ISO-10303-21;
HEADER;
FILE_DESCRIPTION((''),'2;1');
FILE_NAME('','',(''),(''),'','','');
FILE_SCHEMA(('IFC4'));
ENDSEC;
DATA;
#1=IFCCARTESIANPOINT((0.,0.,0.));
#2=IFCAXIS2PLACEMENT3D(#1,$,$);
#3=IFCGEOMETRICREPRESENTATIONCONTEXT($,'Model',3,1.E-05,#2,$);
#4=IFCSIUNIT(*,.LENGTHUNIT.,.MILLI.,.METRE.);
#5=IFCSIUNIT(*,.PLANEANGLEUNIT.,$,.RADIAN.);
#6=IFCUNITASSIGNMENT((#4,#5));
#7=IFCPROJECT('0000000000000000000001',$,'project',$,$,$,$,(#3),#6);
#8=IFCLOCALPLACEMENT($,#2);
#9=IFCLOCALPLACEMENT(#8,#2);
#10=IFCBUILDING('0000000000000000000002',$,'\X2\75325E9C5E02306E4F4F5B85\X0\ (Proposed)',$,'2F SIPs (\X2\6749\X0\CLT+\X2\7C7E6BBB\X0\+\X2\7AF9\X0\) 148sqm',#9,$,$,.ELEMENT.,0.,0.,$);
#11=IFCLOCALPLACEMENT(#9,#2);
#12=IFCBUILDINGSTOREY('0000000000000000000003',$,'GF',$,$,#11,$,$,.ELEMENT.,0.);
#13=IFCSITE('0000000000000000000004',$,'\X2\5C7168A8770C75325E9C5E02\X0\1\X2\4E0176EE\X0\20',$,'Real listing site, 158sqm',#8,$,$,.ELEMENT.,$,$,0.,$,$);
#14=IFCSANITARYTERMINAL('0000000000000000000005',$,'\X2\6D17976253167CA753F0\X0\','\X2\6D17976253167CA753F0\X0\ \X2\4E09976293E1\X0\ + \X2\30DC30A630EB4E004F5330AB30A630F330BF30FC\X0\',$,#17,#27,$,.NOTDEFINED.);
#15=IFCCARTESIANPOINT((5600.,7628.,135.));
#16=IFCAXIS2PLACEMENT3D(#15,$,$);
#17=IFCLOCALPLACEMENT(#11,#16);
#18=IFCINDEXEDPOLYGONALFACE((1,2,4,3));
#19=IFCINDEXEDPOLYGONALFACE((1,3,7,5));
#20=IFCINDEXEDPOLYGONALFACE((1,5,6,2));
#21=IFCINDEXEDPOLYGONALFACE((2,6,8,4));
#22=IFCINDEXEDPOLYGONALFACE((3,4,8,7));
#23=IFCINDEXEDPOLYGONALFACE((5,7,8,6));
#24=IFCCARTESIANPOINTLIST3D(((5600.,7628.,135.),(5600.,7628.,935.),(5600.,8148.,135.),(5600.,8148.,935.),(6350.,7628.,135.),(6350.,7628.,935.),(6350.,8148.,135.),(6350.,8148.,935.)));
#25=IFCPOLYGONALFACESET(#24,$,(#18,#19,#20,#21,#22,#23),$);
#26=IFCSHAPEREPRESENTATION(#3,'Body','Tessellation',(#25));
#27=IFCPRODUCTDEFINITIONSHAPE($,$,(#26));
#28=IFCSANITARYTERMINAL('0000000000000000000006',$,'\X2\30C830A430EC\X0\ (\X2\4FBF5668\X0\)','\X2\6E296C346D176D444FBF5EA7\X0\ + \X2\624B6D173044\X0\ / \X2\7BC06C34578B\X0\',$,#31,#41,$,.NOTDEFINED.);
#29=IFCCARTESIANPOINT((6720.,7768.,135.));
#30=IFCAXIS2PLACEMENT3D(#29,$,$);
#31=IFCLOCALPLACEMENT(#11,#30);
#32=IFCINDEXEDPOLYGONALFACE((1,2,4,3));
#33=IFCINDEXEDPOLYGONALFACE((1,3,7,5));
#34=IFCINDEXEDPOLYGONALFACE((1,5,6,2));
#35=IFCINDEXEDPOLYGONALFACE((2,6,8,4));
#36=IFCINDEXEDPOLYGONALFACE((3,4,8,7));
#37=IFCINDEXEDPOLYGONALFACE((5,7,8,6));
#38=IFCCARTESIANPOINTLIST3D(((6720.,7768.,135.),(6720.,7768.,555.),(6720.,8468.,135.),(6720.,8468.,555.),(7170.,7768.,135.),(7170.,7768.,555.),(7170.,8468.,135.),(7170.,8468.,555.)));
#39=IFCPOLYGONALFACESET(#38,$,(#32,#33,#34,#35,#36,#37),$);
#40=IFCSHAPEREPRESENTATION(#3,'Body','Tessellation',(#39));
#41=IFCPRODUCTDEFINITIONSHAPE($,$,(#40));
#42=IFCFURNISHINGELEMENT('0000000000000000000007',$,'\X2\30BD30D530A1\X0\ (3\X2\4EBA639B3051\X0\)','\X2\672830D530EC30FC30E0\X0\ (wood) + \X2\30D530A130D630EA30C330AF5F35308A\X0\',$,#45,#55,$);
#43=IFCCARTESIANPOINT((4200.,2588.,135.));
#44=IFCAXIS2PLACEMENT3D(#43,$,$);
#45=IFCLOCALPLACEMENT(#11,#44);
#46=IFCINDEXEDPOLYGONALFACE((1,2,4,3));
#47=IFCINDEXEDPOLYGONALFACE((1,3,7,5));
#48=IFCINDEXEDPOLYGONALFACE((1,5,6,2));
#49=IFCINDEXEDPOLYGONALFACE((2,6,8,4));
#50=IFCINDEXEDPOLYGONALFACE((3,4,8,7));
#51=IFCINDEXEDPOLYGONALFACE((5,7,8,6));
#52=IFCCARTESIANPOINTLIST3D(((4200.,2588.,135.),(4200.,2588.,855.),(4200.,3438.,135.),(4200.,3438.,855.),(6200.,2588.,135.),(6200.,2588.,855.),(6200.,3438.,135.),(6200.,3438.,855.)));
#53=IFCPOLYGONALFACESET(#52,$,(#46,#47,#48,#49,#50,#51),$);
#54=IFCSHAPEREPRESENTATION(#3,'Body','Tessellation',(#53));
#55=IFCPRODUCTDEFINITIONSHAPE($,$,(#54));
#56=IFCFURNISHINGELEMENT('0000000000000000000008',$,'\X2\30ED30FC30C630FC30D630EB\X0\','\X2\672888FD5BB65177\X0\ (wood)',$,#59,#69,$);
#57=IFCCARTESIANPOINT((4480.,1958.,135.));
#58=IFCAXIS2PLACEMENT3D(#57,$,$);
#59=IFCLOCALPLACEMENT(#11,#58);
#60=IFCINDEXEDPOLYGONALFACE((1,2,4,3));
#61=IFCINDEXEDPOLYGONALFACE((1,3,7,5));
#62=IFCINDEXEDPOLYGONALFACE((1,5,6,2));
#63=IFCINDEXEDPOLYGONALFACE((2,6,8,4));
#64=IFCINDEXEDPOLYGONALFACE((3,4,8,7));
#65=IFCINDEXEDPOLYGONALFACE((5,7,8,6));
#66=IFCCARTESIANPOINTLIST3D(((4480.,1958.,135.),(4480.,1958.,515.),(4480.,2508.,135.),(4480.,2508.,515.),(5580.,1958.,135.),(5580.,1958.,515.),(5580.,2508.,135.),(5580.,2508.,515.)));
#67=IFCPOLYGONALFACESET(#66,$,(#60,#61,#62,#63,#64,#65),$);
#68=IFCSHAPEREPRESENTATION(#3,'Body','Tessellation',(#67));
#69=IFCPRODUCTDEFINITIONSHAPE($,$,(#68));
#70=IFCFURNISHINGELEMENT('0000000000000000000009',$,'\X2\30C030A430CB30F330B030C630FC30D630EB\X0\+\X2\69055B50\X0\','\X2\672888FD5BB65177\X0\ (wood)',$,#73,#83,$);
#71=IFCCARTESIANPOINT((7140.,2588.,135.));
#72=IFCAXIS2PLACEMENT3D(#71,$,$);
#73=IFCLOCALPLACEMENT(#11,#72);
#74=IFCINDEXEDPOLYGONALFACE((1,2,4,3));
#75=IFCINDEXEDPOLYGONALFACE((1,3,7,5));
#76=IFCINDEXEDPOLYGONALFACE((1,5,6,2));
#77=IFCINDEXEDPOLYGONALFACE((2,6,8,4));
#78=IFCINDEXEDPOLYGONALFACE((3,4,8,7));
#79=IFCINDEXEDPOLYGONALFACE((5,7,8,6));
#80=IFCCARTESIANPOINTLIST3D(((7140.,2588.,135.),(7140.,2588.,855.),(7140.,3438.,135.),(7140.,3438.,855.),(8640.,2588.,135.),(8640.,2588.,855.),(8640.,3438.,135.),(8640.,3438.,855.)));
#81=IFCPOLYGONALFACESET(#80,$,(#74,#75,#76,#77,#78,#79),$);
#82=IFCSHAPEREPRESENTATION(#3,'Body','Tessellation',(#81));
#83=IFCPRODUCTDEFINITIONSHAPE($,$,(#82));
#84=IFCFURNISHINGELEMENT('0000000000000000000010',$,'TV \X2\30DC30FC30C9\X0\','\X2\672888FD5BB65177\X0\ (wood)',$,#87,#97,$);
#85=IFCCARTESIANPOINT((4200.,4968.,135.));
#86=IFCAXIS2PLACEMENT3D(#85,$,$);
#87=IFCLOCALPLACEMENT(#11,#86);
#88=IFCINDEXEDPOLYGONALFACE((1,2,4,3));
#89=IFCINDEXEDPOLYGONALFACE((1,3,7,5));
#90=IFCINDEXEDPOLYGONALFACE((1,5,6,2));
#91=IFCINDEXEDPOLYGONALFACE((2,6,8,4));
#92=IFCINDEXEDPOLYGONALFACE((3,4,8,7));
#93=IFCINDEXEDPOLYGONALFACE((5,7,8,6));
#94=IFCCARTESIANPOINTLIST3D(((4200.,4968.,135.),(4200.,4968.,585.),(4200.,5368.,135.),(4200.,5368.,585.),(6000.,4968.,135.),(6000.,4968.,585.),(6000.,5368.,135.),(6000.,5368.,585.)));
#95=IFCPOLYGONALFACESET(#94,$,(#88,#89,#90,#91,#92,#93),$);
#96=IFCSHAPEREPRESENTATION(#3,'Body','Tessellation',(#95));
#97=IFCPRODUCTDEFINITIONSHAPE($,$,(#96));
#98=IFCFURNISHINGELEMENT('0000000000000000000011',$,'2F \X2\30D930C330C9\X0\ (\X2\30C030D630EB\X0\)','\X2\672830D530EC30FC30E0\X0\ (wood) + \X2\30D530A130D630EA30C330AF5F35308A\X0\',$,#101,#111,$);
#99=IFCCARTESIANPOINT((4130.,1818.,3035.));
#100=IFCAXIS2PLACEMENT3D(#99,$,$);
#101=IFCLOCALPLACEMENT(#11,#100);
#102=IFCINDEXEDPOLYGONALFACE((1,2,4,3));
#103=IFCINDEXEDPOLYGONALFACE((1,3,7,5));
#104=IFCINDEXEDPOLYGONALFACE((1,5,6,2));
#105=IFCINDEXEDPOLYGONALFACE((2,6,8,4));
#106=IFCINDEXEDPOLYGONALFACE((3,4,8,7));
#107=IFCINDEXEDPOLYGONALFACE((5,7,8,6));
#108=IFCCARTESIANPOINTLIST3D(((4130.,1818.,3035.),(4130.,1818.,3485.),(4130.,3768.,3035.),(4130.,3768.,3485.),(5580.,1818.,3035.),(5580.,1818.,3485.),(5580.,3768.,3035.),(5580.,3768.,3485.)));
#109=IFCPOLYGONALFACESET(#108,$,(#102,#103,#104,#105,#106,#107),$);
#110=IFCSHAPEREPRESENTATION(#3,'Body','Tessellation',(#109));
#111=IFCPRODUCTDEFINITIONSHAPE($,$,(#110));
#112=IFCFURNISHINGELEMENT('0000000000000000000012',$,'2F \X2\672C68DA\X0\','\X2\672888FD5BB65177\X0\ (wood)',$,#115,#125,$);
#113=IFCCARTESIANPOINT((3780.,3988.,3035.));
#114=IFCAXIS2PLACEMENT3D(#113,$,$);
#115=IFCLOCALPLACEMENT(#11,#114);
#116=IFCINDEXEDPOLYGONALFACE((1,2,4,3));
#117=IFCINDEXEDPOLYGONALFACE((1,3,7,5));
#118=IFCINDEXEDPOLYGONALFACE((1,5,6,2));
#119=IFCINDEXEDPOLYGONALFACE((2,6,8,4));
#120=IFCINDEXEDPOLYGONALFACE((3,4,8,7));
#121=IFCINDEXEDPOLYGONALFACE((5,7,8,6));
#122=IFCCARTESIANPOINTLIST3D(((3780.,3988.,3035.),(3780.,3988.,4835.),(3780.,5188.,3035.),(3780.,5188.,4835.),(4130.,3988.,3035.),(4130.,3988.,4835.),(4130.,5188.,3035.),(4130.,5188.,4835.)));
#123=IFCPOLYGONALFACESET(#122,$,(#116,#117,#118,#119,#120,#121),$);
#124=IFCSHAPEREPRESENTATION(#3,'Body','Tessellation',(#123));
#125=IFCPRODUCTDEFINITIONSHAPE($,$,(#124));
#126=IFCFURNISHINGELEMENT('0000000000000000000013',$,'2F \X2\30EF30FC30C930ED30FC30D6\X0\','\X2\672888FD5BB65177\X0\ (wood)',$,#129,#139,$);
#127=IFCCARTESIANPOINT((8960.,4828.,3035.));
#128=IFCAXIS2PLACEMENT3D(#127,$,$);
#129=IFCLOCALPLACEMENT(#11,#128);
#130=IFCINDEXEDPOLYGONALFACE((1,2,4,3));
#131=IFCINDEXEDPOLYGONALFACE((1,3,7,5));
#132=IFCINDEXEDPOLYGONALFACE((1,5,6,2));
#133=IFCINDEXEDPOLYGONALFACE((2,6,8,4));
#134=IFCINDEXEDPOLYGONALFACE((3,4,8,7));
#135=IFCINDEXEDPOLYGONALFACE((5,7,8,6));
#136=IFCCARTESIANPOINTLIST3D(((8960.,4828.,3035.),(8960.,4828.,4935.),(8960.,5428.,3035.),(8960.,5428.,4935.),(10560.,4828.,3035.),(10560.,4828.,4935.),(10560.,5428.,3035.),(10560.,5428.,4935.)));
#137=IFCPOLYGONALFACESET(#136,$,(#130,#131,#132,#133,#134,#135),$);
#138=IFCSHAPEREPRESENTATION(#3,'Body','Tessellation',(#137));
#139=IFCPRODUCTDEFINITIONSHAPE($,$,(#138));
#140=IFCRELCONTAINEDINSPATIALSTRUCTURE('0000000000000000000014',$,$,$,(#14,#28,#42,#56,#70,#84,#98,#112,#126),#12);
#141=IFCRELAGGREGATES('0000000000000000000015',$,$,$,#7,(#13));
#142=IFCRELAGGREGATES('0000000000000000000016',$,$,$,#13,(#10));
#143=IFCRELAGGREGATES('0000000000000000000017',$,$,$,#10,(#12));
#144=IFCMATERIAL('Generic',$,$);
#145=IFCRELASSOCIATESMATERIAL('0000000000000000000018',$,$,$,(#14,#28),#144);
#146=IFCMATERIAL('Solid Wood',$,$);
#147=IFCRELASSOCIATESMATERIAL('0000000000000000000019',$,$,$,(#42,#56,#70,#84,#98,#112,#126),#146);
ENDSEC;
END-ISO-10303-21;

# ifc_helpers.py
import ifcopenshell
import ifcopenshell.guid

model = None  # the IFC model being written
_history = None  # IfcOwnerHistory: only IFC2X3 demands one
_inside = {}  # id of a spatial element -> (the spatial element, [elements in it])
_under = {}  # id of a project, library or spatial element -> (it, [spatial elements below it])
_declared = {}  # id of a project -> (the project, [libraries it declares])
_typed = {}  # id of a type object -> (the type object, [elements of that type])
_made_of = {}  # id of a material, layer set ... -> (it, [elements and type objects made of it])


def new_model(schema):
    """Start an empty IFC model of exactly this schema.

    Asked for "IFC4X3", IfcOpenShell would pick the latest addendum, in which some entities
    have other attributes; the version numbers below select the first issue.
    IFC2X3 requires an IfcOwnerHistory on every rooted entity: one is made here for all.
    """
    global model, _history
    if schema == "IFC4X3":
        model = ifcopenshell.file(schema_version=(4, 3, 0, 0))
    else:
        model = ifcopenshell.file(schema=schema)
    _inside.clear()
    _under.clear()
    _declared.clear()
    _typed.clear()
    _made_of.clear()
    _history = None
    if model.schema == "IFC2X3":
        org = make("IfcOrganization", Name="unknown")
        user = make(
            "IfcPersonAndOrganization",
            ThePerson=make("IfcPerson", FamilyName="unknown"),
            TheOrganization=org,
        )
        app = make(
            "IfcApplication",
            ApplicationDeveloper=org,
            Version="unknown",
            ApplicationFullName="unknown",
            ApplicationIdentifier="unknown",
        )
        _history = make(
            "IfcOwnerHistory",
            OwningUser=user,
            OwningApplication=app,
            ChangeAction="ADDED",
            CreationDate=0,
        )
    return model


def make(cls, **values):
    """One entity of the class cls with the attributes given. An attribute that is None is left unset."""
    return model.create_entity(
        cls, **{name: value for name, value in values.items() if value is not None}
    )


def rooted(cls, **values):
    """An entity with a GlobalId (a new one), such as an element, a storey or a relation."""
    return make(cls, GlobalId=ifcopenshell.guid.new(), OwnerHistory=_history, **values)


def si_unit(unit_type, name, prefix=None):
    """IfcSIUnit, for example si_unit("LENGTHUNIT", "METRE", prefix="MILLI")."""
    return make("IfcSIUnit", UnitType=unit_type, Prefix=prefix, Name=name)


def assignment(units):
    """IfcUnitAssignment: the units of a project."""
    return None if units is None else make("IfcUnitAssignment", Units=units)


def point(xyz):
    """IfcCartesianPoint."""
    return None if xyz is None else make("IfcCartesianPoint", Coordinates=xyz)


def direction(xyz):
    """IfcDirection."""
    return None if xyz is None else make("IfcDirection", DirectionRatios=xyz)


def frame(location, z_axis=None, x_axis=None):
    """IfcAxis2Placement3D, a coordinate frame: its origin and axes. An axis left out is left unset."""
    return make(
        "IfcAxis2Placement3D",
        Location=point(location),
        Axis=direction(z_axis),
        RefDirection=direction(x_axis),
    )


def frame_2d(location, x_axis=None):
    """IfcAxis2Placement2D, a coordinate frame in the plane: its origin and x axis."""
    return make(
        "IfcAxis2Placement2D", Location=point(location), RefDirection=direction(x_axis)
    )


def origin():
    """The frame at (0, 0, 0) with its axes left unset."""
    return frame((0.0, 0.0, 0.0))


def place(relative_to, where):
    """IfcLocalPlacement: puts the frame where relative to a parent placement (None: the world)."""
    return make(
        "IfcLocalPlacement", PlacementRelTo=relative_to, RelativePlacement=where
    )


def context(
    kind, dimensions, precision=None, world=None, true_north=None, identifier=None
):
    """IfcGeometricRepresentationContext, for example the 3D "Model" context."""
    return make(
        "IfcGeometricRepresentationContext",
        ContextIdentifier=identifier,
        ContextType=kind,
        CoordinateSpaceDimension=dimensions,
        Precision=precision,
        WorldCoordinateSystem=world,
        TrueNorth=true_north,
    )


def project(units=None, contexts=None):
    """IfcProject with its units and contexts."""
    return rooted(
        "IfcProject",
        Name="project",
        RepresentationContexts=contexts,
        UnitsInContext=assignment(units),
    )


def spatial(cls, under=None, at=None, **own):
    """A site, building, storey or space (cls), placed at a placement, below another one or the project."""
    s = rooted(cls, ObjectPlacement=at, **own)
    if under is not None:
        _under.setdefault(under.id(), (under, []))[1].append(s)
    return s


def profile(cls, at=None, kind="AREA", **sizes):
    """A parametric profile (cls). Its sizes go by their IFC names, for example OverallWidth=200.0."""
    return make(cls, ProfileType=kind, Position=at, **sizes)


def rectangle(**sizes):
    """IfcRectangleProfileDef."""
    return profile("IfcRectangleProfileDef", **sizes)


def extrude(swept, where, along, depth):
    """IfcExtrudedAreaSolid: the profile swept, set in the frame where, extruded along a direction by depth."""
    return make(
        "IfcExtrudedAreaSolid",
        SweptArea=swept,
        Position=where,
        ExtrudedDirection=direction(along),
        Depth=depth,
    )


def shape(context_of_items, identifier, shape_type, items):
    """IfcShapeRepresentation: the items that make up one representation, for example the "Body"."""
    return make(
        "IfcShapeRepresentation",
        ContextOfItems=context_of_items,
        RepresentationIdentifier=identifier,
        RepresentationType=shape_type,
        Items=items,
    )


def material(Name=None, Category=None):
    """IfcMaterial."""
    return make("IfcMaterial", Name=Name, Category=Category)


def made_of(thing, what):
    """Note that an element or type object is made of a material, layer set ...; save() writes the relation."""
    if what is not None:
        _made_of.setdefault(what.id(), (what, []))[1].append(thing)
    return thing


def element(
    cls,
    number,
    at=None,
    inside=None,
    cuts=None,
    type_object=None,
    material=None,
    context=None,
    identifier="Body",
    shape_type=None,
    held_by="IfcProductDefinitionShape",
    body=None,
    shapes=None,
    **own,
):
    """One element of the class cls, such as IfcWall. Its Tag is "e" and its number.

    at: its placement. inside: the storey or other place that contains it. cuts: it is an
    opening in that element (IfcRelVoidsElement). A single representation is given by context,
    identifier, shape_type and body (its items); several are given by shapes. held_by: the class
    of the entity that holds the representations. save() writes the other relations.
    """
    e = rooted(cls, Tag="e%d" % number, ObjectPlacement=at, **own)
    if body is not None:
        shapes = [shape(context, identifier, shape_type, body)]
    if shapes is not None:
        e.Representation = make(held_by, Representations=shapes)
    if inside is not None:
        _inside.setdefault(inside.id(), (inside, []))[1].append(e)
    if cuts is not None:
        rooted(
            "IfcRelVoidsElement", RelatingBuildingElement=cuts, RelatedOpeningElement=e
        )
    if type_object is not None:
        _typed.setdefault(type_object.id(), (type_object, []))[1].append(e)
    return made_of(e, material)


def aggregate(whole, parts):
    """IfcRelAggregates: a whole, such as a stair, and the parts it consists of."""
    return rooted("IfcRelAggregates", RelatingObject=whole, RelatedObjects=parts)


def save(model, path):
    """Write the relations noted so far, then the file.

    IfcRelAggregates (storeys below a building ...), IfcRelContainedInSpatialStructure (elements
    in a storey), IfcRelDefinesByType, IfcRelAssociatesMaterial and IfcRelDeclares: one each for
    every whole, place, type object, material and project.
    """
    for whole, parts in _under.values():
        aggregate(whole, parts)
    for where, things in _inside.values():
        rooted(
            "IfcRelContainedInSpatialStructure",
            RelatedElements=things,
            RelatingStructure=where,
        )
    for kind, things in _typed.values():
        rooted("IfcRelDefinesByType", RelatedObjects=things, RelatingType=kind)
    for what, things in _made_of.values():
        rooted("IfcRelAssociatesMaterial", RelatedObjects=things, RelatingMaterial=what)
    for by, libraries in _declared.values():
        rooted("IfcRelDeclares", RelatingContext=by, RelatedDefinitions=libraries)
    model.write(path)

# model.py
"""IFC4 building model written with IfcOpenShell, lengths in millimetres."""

from ifc_helpers import new_model, si_unit, frame, frame_2d, origin, place, context, project, spatial, rectangle, extrude, material, element, save


model = new_model("IFC4")

# Units and contexts
model_context = context("Model", 3, precision=1e-05, world=origin())
ifc_project = project(units=[si_unit("LENGTHUNIT", "METRE", prefix="MILLI"), si_unit("PLANEANGLEUNIT", "RADIAN")], contexts=[model_context])

# Site, building, storey
site_placement = place(None, origin())
site = spatial("IfcSite", under=ifc_project, at=site_placement, Name="山梨県甲府市1丁目20", ObjectType="Real listing site, 158sqm", CompositionType="ELEMENT", RefElevation=0.0)
building_placement = place(site_placement, origin())
building = spatial("IfcBuilding", under=site, at=building_placement, Name="甲府市の住宅 (Proposed)", ObjectType="2F SIPs (杉CLT+籾殻+竹) 148sqm", CompositionType="ELEMENT", ElevationOfRefHeight=0.0, ElevationOfTerrain=0.0)
storey_placement = place(building_placement, origin())
storey = spatial("IfcBuildingStorey", under=building, at=storey_placement, Name="GF", CompositionType="ELEMENT", Elevation=0.0)

# Shared definitions
ifc_material_1 = material(Name="Solid Wood")

# Shared definitions
ifc_material_2 = material(Name="Generic")

# Sanitary terminals
sanitary_terminal_1_placement = place(storey_placement, frame((5600.0, 7628.0, 135.0)))
element("IfcSanitaryTerminal", 1, at=sanitary_terminal_1_placement, inside=storey, material=ifc_material_2, Name="洗面化粧台", Description="洗面化粧台 三面鏡 + ボウル一体カウンター", PredefinedType="NOTDEFINED", context=model_context, shape_type="SweptSolid", body=[
    extrude(rectangle(XDim=750.0, YDim=520.0, at=frame_2d((375.0, 260.0))), frame((5600.0, 7628.0, 135.0)), (0.0, 0.0, 1.0), 800.0),
])
sanitary_terminal_2_placement = place(storey_placement, frame((6720.0, 7768.0, 135.0)))
element("IfcSanitaryTerminal", 2, at=sanitary_terminal_2_placement, inside=storey, material=ifc_material_2, Name="トイレ (便器)", Description="温水洗浄便座 + 手洗い / 節水型", PredefinedType="NOTDEFINED", context=model_context, shape_type="SweptSolid", body=[
    extrude(rectangle(XDim=450.0, YDim=700.0, at=frame_2d((225.0, 350.0))), frame((6720.0, 7768.0, 135.0)), (0.0, 0.0, 1.0), 420.0),
])

# Furnishing elements
furnishing_1_placement = place(storey_placement, frame((4200.0, 2588.0, 135.0)))
element("IfcFurnishingElement", 3, at=furnishing_1_placement, inside=storey, material=ifc_material_1, Name="ソファ (3人掛け)", Description="木フレーム (wood) + ファブリック張り", context=model_context, shape_type="SweptSolid", body=[
    extrude(rectangle(XDim=2000.0, YDim=850.0, at=frame_2d((1000.0, 425.0))), frame((4200.0, 2588.0, 135.0)), (0.0, 0.0, 1.0), 720.0),
])
furnishing_2_placement = place(storey_placement, frame((4480.0, 1958.0, 135.0)))
element("IfcFurnishingElement", 4, at=furnishing_2_placement, inside=storey, material=ifc_material_1, Name="ローテーブル", Description="木製家具 (wood)", context=model_context, shape_type="SweptSolid", body=[
    extrude(rectangle(XDim=1100.0, YDim=550.0, at=frame_2d((550.0, 275.0))), frame((4480.0, 1958.0, 135.0)), (0.0, 0.0, 1.0), 380.0),
])
furnishing_3_placement = place(storey_placement, frame((7140.0, 2588.0, 135.0)))
element("IfcFurnishingElement", 5, at=furnishing_3_placement, inside=storey, material=ifc_material_1, Name="ダイニングテーブル+椅子", Description="木製家具 (wood)", context=model_context, shape_type="SweptSolid", body=[
    extrude(rectangle(XDim=1500.0, YDim=850.0, at=frame_2d((750.0, 425.0))), frame((7140.0, 2588.0, 135.0)), (0.0, 0.0, 1.0), 720.0),
])
furnishing_4_placement = place(storey_placement, frame((4200.0, 4968.0, 135.0)))
element("IfcFurnishingElement", 6, at=furnishing_4_placement, inside=storey, material=ifc_material_1, Name="TV ボード", Description="木製家具 (wood)", context=model_context, shape_type="SweptSolid", body=[
    extrude(rectangle(XDim=1800.0, YDim=400.0, at=frame_2d((900.0, 200.0))), frame((4200.0, 4968.0, 135.0)), (0.0, 0.0, 1.0), 450.0),
])
furnishing_5_placement = place(storey_placement, frame((4130.0, 1818.0, 3035.0)))
element("IfcFurnishingElement", 7, at=furnishing_5_placement, inside=storey, material=ifc_material_1, Name="2F ベッド (ダブル)", Description="木フレーム (wood) + ファブリック張り", context=model_context, shape_type="SweptSolid", body=[
    extrude(rectangle(XDim=1450.0, YDim=1950.0, at=frame_2d((725.0, 975.0))), frame((4130.0, 1818.0, 3035.0)), (0.0, 0.0, 1.0), 450.0),
])
furnishing_6_placement = place(storey_placement, frame((3780.0, 3988.0, 3035.0)))
element("IfcFurnishingElement", 8, at=furnishing_6_placement, inside=storey, material=ifc_material_1, Name="2F 本棚", Description="木製家具 (wood)", context=model_context, shape_type="SweptSolid", body=[
    extrude(rectangle(XDim=350.0, YDim=1200.0, at=frame_2d((175.0, 600.0))), frame((3780.0, 3988.0, 3035.0)), (0.0, 0.0, 1.0), 1800.0),
])
furnishing_7_placement = place(storey_placement, frame((8960.0, 4828.0, 3035.0)))
element("IfcFurnishingElement", 9, at=furnishing_7_placement, inside=storey, material=ifc_material_1, Name="2F ワードローブ", Description="木製家具 (wood)", context=model_context, shape_type="SweptSolid", body=[
    extrude(rectangle(XDim=1600.0, YDim=600.0, at=frame_2d((800.0, 300.0))), frame((8960.0, 4828.0, 3035.0)), (0.0, 0.0, 1.0), 1900.0),
])

save(model, "model.ifc")
